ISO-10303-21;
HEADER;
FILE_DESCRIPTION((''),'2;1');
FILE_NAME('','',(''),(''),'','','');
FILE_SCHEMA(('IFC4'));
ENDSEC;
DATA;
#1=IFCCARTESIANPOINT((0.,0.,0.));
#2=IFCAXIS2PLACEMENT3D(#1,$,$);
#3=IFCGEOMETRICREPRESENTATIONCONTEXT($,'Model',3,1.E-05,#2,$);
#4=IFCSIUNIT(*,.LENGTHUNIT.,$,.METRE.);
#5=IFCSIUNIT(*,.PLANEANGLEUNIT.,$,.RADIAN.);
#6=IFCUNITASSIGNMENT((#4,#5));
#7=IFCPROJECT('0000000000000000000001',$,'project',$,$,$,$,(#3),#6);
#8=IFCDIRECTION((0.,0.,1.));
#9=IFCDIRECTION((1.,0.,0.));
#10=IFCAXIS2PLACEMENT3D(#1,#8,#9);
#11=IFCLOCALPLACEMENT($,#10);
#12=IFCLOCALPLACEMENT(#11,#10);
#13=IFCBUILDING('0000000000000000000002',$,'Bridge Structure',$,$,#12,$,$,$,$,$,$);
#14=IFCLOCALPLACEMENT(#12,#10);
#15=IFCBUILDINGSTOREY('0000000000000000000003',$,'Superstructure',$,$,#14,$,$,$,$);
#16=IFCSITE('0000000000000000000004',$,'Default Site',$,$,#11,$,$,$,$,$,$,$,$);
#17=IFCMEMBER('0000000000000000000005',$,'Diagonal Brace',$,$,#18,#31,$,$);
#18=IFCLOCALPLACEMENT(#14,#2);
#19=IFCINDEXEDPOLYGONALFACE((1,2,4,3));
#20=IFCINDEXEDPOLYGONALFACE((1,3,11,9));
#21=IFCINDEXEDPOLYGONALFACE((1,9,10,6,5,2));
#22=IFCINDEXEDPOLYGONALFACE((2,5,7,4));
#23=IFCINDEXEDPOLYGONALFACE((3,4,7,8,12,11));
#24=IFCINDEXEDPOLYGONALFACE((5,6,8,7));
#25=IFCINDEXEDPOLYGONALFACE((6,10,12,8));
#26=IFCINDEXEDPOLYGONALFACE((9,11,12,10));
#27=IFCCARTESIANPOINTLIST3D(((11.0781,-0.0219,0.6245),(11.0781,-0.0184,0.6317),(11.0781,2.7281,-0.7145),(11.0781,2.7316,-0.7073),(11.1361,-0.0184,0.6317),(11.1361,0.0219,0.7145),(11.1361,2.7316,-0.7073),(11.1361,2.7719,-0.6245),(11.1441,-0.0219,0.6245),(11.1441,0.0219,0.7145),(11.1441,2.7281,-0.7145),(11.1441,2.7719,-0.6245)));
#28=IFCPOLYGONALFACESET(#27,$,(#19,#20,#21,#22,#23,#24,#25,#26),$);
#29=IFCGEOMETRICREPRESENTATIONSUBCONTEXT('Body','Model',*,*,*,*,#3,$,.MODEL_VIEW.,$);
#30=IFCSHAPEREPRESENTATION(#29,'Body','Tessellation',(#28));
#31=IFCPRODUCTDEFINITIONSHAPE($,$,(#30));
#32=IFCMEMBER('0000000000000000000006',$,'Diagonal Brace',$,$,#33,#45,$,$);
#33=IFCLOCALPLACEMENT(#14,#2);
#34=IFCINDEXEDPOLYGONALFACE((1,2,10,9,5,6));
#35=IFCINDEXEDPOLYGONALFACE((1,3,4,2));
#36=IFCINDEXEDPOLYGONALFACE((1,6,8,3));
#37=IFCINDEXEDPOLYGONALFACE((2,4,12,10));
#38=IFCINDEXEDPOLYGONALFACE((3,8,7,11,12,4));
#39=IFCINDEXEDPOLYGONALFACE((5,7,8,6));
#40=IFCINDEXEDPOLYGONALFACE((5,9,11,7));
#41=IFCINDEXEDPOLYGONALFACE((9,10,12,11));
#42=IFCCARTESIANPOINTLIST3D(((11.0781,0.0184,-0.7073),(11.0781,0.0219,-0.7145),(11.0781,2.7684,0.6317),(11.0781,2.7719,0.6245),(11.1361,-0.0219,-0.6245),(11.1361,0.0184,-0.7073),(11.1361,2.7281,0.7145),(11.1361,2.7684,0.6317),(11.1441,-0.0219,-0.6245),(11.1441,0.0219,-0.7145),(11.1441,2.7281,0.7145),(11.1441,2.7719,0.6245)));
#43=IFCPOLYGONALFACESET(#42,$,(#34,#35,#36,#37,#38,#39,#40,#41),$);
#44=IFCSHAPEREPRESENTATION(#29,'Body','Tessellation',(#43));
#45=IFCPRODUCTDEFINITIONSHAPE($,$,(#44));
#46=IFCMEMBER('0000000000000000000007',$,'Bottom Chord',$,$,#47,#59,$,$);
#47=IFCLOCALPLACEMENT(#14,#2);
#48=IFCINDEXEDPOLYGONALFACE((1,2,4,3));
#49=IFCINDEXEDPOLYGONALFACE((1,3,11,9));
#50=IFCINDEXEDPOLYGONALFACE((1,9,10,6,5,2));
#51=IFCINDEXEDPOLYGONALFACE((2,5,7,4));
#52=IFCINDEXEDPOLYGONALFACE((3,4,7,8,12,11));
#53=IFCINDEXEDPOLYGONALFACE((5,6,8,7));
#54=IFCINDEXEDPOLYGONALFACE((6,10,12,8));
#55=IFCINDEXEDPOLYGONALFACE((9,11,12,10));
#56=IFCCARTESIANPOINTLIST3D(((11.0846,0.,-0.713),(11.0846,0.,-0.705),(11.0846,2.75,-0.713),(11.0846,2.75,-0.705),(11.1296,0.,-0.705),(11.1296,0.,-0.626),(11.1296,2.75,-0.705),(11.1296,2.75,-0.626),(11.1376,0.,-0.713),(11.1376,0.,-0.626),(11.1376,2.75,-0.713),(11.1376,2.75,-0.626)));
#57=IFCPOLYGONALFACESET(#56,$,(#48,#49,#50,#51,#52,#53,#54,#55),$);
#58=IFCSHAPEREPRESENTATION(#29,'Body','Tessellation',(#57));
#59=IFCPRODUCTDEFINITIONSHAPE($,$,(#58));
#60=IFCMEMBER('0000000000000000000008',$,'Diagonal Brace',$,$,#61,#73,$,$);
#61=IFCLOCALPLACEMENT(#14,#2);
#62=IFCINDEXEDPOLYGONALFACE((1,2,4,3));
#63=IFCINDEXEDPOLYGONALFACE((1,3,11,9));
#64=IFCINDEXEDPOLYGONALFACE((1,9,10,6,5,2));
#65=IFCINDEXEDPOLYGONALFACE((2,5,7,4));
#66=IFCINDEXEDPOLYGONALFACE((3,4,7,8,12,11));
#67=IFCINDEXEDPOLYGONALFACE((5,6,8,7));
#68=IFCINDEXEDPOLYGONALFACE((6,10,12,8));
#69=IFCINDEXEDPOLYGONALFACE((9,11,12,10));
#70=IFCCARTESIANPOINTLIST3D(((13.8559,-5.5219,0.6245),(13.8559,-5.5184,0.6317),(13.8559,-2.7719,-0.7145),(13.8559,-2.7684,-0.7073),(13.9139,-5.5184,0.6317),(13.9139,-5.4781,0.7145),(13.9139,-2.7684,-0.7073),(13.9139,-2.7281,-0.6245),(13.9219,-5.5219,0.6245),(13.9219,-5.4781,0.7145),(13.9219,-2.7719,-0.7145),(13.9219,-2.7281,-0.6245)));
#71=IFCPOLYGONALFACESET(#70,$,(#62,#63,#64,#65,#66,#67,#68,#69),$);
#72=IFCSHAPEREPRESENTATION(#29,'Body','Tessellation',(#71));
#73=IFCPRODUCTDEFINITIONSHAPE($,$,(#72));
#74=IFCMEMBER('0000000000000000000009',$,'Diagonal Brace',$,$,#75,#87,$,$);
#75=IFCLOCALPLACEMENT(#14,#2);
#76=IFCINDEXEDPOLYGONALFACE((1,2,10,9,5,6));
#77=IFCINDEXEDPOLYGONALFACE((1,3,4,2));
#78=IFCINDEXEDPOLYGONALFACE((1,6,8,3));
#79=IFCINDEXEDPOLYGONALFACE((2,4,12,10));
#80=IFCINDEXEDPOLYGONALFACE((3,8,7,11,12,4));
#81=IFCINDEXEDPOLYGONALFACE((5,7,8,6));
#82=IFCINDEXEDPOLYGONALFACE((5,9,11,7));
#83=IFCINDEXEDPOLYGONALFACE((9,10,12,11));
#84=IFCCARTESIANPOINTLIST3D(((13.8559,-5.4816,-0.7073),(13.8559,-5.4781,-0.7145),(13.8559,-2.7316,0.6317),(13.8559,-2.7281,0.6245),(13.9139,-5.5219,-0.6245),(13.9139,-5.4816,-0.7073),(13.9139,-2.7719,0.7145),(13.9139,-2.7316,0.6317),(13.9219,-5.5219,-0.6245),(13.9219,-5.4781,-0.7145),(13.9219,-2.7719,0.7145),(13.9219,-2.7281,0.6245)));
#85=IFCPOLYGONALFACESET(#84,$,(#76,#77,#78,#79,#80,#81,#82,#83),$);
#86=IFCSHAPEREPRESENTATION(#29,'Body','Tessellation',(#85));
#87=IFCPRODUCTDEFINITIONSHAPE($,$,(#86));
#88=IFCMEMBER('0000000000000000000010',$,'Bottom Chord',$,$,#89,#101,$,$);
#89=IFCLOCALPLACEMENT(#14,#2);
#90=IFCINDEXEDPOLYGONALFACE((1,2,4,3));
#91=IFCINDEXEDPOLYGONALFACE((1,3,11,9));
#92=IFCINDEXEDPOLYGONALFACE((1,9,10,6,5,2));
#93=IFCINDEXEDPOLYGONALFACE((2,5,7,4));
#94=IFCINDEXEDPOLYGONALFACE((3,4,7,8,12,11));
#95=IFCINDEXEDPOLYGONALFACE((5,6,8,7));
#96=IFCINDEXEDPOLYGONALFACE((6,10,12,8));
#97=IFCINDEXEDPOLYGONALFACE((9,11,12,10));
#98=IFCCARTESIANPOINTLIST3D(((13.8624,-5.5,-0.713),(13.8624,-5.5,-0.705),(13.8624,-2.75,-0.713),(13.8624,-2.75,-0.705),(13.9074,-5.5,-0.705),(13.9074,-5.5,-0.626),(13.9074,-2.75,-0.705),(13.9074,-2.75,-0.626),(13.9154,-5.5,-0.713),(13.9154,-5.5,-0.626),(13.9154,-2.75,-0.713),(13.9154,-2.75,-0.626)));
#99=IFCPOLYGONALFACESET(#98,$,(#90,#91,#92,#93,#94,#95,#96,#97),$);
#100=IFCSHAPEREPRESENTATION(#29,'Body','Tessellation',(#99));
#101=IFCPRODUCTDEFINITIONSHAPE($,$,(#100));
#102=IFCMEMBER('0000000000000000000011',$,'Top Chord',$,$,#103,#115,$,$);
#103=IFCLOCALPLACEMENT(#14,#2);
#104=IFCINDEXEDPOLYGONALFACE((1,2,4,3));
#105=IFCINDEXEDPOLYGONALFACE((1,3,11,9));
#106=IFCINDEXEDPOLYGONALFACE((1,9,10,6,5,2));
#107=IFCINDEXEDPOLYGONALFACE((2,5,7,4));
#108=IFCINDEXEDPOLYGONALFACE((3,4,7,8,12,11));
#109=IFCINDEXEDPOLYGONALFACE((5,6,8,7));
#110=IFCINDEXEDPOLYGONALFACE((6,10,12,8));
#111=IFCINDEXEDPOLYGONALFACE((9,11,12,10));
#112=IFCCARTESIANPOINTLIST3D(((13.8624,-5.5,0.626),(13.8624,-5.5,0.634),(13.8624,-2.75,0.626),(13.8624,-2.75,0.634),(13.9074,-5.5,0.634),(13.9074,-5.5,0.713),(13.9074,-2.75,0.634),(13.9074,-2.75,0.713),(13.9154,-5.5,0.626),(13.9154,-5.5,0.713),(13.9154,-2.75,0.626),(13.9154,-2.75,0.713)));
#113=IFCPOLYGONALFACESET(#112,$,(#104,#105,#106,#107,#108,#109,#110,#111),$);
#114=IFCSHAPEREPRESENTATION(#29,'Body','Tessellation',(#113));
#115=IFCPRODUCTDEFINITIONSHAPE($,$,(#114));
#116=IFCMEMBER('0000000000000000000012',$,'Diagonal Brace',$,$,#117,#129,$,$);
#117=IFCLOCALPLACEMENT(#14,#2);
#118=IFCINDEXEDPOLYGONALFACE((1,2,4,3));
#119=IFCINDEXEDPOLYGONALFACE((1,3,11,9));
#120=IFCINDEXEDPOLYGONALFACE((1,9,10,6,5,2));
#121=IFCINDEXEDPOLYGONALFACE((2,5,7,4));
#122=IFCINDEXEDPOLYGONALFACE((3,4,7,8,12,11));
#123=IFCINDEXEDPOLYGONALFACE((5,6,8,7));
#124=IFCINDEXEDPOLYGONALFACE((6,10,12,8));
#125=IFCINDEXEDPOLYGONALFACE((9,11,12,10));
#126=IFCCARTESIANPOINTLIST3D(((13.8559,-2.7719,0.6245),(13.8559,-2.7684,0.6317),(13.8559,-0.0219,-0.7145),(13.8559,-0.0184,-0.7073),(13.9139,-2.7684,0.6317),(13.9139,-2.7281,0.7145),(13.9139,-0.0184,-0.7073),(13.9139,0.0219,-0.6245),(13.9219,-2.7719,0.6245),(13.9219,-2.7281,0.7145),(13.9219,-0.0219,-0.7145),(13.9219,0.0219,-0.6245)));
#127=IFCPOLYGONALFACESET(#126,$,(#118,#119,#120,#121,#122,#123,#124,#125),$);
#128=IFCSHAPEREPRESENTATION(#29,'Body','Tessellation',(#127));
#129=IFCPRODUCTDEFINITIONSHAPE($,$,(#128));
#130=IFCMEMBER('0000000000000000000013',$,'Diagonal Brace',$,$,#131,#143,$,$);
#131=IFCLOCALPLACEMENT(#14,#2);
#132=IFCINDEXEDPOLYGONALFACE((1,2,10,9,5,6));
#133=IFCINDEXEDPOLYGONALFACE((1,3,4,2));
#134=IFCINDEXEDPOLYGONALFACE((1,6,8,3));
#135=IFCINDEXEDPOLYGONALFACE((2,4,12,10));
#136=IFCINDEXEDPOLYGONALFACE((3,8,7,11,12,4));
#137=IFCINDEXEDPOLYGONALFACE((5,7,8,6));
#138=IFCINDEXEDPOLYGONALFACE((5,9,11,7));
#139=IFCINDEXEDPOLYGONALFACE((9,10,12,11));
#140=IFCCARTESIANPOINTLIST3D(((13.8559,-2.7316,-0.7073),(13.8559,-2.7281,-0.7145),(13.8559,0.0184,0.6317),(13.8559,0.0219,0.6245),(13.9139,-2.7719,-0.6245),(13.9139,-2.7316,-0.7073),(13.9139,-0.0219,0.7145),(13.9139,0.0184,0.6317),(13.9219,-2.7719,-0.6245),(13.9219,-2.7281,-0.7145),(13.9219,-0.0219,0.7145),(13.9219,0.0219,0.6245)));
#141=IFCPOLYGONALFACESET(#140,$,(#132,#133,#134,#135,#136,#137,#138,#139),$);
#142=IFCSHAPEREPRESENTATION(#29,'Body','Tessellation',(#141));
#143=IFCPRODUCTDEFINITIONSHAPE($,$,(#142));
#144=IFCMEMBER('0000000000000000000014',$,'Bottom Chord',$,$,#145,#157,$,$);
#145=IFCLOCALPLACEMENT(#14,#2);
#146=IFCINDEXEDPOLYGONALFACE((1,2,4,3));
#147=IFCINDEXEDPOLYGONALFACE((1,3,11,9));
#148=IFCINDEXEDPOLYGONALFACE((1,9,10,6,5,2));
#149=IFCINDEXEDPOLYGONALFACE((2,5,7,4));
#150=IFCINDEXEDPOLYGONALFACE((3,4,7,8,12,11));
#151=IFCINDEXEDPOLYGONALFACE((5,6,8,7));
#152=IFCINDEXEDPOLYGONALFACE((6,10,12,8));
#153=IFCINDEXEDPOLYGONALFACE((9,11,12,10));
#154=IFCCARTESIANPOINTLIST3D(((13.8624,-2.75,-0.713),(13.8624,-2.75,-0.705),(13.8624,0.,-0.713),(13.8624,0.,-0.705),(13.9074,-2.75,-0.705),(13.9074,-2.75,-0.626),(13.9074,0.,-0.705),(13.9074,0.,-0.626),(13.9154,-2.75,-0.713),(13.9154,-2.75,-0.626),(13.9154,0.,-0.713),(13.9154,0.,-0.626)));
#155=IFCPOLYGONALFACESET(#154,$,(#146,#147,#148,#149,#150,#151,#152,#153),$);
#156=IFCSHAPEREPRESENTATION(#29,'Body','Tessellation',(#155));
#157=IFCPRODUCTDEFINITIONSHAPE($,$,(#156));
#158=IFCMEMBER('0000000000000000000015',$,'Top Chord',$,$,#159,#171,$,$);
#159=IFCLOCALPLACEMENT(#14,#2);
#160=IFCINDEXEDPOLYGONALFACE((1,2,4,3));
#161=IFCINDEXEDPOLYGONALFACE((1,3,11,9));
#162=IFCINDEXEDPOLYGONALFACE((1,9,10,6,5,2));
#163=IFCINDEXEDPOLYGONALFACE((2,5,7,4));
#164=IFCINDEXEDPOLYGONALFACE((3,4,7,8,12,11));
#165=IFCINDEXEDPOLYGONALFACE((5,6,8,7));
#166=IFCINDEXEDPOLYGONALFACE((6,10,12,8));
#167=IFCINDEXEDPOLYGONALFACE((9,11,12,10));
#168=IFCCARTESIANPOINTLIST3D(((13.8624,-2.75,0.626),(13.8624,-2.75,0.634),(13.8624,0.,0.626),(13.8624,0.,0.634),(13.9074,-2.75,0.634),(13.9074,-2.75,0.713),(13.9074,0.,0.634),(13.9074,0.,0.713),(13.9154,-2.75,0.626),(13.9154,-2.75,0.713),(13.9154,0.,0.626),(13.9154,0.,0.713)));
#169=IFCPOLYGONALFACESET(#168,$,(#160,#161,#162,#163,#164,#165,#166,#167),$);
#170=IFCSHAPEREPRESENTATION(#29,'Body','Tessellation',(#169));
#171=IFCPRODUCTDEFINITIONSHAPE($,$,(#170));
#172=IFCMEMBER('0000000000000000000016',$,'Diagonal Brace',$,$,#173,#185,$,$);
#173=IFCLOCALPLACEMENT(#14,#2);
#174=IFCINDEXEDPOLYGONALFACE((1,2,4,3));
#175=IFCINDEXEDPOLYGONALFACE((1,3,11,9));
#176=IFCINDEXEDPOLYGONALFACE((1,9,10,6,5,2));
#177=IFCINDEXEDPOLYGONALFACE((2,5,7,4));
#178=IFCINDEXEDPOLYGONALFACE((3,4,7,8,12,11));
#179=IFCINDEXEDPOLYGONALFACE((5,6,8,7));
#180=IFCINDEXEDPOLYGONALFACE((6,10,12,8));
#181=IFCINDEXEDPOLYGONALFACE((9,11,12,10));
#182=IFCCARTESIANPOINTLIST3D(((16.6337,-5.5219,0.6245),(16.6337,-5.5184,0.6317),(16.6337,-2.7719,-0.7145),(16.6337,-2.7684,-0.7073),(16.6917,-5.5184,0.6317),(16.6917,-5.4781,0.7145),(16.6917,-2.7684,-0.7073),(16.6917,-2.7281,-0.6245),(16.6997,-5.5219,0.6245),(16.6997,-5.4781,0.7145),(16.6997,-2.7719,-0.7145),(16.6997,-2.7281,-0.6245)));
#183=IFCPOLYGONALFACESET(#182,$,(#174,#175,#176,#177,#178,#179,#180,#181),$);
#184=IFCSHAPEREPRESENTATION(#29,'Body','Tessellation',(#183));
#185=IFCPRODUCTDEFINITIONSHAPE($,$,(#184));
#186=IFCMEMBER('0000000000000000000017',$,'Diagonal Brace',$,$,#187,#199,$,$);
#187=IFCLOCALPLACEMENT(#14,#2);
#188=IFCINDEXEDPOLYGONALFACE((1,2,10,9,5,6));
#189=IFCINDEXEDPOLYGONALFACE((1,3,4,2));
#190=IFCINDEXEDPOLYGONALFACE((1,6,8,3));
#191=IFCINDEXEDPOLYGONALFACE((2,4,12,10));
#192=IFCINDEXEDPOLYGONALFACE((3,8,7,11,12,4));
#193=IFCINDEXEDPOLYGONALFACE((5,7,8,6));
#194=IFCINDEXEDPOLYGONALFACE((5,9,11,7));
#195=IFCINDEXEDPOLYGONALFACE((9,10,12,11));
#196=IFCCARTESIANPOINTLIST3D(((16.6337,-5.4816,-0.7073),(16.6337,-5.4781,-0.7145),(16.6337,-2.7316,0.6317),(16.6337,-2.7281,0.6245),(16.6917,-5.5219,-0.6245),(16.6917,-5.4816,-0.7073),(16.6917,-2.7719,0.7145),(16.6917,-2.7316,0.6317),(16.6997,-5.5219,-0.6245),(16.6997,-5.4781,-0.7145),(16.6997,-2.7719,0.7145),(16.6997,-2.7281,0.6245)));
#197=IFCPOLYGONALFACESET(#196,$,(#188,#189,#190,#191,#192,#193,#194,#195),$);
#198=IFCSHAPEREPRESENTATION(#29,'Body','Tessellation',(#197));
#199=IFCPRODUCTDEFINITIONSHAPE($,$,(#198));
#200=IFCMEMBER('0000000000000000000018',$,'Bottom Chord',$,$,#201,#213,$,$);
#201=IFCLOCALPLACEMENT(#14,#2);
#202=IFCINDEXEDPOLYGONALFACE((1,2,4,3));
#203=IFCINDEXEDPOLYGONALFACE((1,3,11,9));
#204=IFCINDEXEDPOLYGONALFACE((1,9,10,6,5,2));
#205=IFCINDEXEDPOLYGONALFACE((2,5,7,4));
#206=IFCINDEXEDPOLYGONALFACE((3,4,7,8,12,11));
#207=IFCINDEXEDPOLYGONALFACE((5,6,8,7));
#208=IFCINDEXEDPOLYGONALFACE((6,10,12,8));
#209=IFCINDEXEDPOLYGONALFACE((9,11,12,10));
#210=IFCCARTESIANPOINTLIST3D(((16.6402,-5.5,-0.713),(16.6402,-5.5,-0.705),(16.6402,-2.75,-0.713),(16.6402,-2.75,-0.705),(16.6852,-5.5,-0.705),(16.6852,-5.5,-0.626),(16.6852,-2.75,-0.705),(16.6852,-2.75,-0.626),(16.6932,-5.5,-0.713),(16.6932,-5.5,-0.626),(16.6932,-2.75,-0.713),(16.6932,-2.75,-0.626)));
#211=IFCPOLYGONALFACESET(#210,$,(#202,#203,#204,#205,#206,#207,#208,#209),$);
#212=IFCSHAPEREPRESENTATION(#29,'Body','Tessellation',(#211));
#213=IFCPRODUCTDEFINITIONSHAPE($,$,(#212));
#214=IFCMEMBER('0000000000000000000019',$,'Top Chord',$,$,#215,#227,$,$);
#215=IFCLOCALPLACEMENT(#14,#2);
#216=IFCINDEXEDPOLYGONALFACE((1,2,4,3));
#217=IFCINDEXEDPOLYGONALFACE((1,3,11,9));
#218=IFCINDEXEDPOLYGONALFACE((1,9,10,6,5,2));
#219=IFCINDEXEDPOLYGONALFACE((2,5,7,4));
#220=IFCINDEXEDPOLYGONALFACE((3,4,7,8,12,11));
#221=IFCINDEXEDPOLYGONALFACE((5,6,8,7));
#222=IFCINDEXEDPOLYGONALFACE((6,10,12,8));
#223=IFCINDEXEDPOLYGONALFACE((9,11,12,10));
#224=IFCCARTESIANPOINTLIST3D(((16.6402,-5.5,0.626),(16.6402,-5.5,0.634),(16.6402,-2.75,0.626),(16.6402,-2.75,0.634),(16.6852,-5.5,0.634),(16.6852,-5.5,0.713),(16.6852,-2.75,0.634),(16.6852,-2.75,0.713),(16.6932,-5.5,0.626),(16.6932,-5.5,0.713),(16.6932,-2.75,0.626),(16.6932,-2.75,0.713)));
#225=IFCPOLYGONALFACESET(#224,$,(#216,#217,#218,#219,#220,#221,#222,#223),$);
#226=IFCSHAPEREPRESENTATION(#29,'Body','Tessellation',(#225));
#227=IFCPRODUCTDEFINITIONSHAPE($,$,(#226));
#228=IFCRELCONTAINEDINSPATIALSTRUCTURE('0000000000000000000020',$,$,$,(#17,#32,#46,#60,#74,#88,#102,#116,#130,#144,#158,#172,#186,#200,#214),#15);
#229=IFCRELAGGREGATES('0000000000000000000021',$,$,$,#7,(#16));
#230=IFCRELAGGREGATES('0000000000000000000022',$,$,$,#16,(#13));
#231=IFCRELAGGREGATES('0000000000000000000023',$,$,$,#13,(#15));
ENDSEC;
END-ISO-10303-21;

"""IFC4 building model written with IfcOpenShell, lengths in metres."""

from ifc_helpers import new_model, si_unit, frame, origin, origin_with_axes, origin_2d_with_axis, place, context, subcontext, project, spatial, l_section, extrude, element, save


model = new_model("IFC4")

# Units and contexts
model_context = context("Model", 3, precision=1e-05, world=origin())
body_context = subcontext(model_context, "Body", "Model", "MODEL_VIEW")
ifc_project = project(units=[si_unit("LENGTHUNIT", "METRE"), si_unit("PLANEANGLEUNIT", "RADIAN")], contexts=[model_context])

# Site, building, storey
site_placement = place(None, origin_with_axes())
site = spatial("IfcSite", under=ifc_project, at=site_placement, Name="Default Site")
building_placement = place(site_placement, origin_with_axes())
building = spatial("IfcBuilding", under=site, at=building_placement, Name="Bridge Structure")
storey_placement = place(building_placement, origin_with_axes())
storey = spatial("IfcBuildingStorey", under=building, at=storey_placement, Name="Superstructure")

# Members
for number, where, z_axis, x_axis, name in (
    (1, (11.1111, 0.0, 0.6695), (0.0, 0.899086, -0.437773), (-1.0, 0.0, 0.0), "Diagonal Brace"),
    (2, (11.1111, 0.0, -0.6695), (0.0, 0.899086, 0.437773), (-1.0, 0.0, 0.0), "Diagonal Brace"),
):
    element("IfcMember", number, at=place(storey_placement, frame(where, z_axis=z_axis, x_axis=x_axis)), inside=storey, Name=name, context=body_context, shape_type="SweptSolid", body=[
        extrude(l_section(Depth=0.1, Width=0.066, Thickness=0.008, at=origin_2d_with_axis()), origin_with_axes(), (0.0, 0.0, 1.0), 3.0587),
    ])
member_placement = place(storey_placement, frame((11.1111, 0.0, -0.6695), z_axis=(0.0, 1.0, 0.0), x_axis=(-1.0, 0.0, 0.0)))
element("IfcMember", 3, at=member_placement, inside=storey, Name="Bottom Chord", context=body_context, shape_type="SweptSolid", body=[
    extrude(l_section(Depth=0.087, Width=0.053, Thickness=0.008, at=origin_2d_with_axis()), origin_with_axes(), (0.0, 0.0, 1.0), 2.75),
])
for number, where, z_axis, x_axis, name in (
    (4, (13.8889, -5.5, 0.6695), (0.0, 0.899086, -0.437773), (-1.0, 0.0, 0.0), "Diagonal Brace"),
    (5, (13.8889, -5.5, -0.6695), (0.0, 0.899086, 0.437773), (-1.0, 0.0, 0.0), "Diagonal Brace"),
):
    element("IfcMember", number, at=place(storey_placement, frame(where, z_axis=z_axis, x_axis=x_axis)), inside=storey, Name=name, context=body_context, shape_type="SweptSolid", body=[
        extrude(l_section(Depth=0.1, Width=0.066, Thickness=0.008, at=origin_2d_with_axis()), origin_with_axes(), (0.0, 0.0, 1.0), 3.0587),
    ])
for number, where, z_axis, x_axis, name in (
    (6, (13.8889, -5.5, -0.6695), (0.0, 1.0, 0.0), (-1.0, 0.0, 0.0), "Bottom Chord"),
    (7, (13.8889, -5.5, 0.6695), (0.0, 1.0, 0.0), (-1.0, 0.0, 0.0), "Top Chord"),
):
    element("IfcMember", number, at=place(storey_placement, frame(where, z_axis=z_axis, x_axis=x_axis)), inside=storey, Name=name, context=body_context, shape_type="SweptSolid", body=[
        extrude(l_section(Depth=0.087, Width=0.053, Thickness=0.008, at=origin_2d_with_axis()), origin_with_axes(), (0.0, 0.0, 1.0), 2.75),
    ])
for number, where, z_axis, x_axis, name in (
    (8, (13.8889, -2.75, 0.6695), (0.0, 0.899086, -0.437773), (-1.0, 0.0, 0.0), "Diagonal Brace"),
    (9, (13.8889, -2.75, -0.6695), (0.0, 0.899086, 0.437773), (-1.0, 0.0, 0.0), "Diagonal Brace"),
):
    element("IfcMember", number, at=place(storey_placement, frame(where, z_axis=z_axis, x_axis=x_axis)), inside=storey, Name=name, context=body_context, shape_type="SweptSolid", body=[
        extrude(l_section(Depth=0.1, Width=0.066, Thickness=0.008, at=origin_2d_with_axis()), origin_with_axes(), (0.0, 0.0, 1.0), 3.0587),
    ])
for number, where, z_axis, x_axis, name in (
    (10, (13.8889, -2.75, -0.6695), (0.0, 1.0, 0.0), (-1.0, 0.0, 0.0), "Bottom Chord"),
    (11, (13.8889, -2.75, 0.6695), (0.0, 1.0, 0.0), (-1.0, 0.0, 0.0), "Top Chord"),
):
    element("IfcMember", number, at=place(storey_placement, frame(where, z_axis=z_axis, x_axis=x_axis)), inside=storey, Name=name, context=body_context, shape_type="SweptSolid", body=[
        extrude(l_section(Depth=0.087, Width=0.053, Thickness=0.008, at=origin_2d_with_axis()), origin_with_axes(), (0.0, 0.0, 1.0), 2.75),
    ])
for number, where, z_axis, x_axis, name in (
    (12, (16.6667, -5.5, 0.6695), (0.0, 0.899086, -0.437773), (-1.0, 0.0, 0.0), "Diagonal Brace"),
    (13, (16.6667, -5.5, -0.6695), (0.0, 0.899086, 0.437773), (-1.0, 0.0, 0.0), "Diagonal Brace"),
):
    element("IfcMember", number, at=place(storey_placement, frame(where, z_axis=z_axis, x_axis=x_axis)), inside=storey, Name=name, context=body_context, shape_type="SweptSolid", body=[
        extrude(l_section(Depth=0.1, Width=0.066, Thickness=0.008, at=origin_2d_with_axis()), origin_with_axes(), (0.0, 0.0, 1.0), 3.0587),
    ])
for number, where, z_axis, x_axis, name in (
    (14, (16.6667, -5.5, -0.6695), (0.0, 1.0, 0.0), (-1.0, 0.0, 0.0), "Bottom Chord"),
    (15, (16.6667, -5.5, 0.6695), (0.0, 1.0, 0.0), (-1.0, 0.0, 0.0), "Top Chord"),
):
    element("IfcMember", number, at=place(storey_placement, frame(where, z_axis=z_axis, x_axis=x_axis)), inside=storey, Name=name, context=body_context, shape_type="SweptSolid", body=[
        extrude(l_section(Depth=0.087, Width=0.053, Thickness=0.008, at=origin_2d_with_axis()), origin_with_axes(), (0.0, 0.0, 1.0), 2.75),
    ])

save(model, "model.ifc")
